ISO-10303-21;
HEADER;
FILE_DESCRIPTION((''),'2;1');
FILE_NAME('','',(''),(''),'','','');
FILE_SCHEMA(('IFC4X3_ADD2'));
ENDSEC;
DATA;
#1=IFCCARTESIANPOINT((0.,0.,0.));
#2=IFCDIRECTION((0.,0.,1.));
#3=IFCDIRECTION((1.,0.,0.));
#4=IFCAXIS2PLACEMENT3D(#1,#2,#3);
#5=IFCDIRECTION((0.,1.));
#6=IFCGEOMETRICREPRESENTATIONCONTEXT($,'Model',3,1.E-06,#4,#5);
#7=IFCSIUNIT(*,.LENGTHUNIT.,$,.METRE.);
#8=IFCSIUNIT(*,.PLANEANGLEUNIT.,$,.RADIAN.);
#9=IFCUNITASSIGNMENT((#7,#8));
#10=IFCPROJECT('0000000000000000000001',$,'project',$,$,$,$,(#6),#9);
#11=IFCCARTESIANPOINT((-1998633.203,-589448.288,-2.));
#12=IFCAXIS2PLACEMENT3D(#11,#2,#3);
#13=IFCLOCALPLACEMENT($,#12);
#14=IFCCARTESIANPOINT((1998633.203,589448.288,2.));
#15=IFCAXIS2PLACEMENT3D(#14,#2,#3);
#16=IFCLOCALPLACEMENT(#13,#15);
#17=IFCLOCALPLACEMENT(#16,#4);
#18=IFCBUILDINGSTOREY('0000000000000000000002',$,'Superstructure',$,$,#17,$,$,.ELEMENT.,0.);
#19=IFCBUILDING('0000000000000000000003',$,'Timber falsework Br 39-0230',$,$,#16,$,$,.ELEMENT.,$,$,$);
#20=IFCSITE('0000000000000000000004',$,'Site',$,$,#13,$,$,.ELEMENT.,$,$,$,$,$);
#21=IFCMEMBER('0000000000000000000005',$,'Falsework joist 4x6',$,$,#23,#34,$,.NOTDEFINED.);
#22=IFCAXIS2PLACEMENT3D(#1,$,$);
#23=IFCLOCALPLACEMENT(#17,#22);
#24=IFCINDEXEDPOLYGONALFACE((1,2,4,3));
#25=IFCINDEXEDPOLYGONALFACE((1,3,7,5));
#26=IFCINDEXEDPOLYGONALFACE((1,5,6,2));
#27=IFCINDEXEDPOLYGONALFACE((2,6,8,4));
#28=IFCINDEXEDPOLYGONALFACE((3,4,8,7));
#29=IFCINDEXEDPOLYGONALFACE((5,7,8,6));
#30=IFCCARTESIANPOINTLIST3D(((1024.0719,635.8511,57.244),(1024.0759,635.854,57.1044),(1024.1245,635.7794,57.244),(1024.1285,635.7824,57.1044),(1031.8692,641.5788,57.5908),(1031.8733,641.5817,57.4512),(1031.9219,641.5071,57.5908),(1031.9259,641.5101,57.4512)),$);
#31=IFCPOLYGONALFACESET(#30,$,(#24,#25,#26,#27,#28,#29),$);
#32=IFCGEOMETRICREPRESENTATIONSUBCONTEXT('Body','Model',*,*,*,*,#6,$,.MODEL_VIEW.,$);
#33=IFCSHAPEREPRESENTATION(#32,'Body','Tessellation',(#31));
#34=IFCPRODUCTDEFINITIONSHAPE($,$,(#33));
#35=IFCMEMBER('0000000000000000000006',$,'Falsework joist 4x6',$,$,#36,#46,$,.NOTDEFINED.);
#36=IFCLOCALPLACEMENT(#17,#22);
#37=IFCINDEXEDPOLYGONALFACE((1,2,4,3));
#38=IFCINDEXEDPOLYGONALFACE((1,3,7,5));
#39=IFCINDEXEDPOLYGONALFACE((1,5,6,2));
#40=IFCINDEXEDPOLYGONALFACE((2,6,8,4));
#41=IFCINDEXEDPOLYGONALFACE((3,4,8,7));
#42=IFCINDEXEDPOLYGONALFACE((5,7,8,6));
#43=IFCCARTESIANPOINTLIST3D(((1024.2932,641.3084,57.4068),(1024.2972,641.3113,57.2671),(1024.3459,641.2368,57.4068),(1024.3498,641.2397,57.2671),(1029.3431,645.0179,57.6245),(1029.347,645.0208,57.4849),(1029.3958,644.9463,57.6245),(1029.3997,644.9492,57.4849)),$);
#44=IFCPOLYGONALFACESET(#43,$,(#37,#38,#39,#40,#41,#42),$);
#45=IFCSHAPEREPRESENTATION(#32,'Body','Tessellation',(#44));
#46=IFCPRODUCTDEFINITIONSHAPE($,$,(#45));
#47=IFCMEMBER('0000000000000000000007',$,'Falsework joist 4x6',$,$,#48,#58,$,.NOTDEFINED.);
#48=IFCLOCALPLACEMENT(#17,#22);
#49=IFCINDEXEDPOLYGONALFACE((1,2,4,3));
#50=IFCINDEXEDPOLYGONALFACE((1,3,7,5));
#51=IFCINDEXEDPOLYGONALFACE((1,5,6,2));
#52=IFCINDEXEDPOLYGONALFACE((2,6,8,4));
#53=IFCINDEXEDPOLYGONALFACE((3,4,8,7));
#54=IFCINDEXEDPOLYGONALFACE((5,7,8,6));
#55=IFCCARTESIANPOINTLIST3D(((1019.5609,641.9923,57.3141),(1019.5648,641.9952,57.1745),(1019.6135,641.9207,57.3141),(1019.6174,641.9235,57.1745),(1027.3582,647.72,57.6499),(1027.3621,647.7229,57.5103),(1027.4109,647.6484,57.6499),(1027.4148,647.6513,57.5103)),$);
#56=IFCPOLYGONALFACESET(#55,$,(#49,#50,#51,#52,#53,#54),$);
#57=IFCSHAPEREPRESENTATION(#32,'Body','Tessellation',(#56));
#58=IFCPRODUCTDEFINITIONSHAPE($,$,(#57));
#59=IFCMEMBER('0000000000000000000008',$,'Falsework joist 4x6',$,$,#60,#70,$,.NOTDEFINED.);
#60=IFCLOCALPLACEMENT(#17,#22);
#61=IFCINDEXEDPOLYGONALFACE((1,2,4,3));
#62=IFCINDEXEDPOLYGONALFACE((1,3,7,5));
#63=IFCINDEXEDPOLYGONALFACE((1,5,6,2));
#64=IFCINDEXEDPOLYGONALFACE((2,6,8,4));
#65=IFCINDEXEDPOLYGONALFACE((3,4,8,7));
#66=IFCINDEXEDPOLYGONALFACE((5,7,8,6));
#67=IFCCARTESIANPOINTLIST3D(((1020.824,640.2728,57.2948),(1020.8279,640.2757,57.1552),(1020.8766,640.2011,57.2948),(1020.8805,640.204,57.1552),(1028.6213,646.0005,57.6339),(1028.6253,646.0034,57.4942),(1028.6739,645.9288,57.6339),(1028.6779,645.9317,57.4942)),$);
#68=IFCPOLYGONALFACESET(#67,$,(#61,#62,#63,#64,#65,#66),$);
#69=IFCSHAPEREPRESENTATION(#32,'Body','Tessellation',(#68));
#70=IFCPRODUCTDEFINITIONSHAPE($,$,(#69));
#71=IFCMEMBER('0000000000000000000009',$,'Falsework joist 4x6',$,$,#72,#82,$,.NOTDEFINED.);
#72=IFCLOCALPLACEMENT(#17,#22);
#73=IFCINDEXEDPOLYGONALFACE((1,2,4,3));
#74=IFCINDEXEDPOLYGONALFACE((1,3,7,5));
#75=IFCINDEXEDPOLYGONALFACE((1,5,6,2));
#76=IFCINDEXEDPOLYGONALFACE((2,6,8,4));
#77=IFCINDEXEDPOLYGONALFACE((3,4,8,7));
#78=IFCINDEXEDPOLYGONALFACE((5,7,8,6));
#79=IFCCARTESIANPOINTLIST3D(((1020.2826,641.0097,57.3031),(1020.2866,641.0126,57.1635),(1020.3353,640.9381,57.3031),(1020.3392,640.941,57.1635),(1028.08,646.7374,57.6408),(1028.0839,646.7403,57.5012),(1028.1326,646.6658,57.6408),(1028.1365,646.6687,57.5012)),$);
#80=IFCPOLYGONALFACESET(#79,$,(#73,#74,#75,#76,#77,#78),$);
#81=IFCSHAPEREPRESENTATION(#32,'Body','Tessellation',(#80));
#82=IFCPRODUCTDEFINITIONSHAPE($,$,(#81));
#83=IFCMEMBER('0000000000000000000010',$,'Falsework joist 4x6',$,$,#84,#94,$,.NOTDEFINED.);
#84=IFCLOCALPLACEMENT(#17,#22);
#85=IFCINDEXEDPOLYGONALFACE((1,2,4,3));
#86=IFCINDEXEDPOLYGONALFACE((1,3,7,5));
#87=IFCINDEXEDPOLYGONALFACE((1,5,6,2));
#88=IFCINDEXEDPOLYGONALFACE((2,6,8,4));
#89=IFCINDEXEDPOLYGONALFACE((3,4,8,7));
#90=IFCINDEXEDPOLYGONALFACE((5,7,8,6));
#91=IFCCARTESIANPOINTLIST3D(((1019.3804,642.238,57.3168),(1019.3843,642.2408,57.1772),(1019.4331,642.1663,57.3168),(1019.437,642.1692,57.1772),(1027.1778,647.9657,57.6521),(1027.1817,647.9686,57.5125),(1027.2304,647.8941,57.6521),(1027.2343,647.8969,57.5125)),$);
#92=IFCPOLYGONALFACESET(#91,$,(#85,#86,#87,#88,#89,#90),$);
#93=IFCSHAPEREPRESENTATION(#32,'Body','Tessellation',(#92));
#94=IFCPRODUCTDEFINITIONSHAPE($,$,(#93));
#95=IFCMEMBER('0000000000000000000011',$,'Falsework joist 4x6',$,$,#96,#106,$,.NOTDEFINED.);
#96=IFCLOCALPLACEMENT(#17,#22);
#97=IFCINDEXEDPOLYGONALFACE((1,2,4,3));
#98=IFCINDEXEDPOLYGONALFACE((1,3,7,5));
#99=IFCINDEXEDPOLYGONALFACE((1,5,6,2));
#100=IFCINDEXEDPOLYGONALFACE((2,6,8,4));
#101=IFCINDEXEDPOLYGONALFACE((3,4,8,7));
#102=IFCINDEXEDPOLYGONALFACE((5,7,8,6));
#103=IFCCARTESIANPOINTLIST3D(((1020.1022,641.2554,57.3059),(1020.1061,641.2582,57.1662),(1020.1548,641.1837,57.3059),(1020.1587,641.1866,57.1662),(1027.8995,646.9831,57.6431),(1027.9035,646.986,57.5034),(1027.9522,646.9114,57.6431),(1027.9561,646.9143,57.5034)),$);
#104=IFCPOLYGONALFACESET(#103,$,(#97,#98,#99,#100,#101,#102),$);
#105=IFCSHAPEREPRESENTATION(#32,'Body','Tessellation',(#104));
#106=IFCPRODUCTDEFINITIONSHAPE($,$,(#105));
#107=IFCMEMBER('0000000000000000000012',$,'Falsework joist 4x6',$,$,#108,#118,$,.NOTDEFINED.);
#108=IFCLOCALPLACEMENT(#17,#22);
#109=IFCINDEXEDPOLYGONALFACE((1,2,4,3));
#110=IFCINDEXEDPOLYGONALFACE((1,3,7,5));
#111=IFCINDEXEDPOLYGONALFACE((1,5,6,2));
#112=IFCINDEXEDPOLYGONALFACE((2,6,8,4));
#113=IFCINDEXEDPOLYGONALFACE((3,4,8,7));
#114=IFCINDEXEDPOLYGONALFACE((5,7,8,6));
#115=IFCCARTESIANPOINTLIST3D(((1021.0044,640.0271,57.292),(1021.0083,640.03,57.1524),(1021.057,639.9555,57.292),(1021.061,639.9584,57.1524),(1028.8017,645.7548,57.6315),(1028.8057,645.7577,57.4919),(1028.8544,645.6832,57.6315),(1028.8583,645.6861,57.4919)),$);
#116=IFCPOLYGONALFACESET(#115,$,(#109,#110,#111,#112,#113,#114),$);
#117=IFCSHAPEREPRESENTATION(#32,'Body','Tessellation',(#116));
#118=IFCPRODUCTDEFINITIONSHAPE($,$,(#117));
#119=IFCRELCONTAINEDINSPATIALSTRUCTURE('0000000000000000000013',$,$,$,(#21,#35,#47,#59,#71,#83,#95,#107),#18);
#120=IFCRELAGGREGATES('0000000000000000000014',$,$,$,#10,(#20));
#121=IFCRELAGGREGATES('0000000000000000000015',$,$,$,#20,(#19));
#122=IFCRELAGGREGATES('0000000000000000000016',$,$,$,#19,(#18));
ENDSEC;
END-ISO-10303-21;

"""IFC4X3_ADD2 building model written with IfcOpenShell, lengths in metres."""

from ifc_helpers import new_model, si_unit, direction, frame, frame_2d, origin, origin_with_axes, place, context, subcontext, project, spatial, rectangle, extrude, element, save


model = new_model("IFC4X3_ADD2")

# Units and contexts
model_context = context("Model", 3, precision=1e-06, world=origin_with_axes(), true_north=direction((0.0, 1.0)))
body_context = subcontext(model_context, "Body", "Model", "MODEL_VIEW")
ifc_project = project(units=[si_unit("LENGTHUNIT", "METRE"), si_unit("PLANEANGLEUNIT", "RADIAN")], contexts=[model_context])

# Site, building, storey
site_placement = place(None, frame((-1998633.203, -589448.288, -2.0), z_axis=(0.0, 0.0, 1.0), x_axis=(1.0, 0.0, 0.0)))
site = spatial("IfcSite", under=ifc_project, at=site_placement, Name="Site", CompositionType="ELEMENT")
building_placement = place(site_placement, frame((1998633.203, 589448.288, 2.0), z_axis=(0.0, 0.0, 1.0), x_axis=(1.0, 0.0, 0.0)))
building = spatial("IfcBuilding", under=site, at=building_placement, Name="Timber falsework Br 39-0230", CompositionType="ELEMENT")
storey_placement = place(building_placement, origin_with_axes())
storey = spatial("IfcBuildingStorey", under=building, at=storey_placement, Name="Superstructure", CompositionType="ELEMENT", Elevation=0.0)

# Members
member_1_placement = place(storey_placement, frame((1024.1022, 635.8182, 57.1044), z_axis=(0.805411, 0.591633, 0.035824), x_axis=(-0.592013, 0.805928, 0.0)))
element("IfcMember", 1, at=member_1_placement, inside=storey, Name="Falsework joist 4x6", PredefinedType="NOTDEFINED", context=body_context, shape_type="SweptSolid", body=[
    extrude(rectangle(XDim=0.0889, YDim=0.1397, at=frame_2d((0.0, 0.0698))), origin(), (0.0, 0.0, 1.0), 9.6812),
])
member_2_placement = place(storey_placement, frame((1024.3235, 641.2755, 57.2671), z_axis=(0.805442, 0.591656, 0.034733), x_axis=(-0.592013, 0.805928, 0.0)))
element("IfcMember", 2, at=member_2_placement, inside=storey, Name="Falsework joist 4x6", PredefinedType="NOTDEFINED", context=body_context, shape_type="SweptSolid", body=[
    extrude(rectangle(XDim=0.0889, YDim=0.1397, at=frame_2d((0.0, 0.0698))), origin(), (0.0, 0.0, 1.0), 6.2697),
])
member_3_placement = place(storey_placement, frame((1019.5911, 641.9594, 57.1745), z_axis=(0.805443, 0.591657, 0.034688), x_axis=(-0.592013, 0.805928, 0.0)))
element("IfcMember", 3, at=member_3_placement, inside=storey, Name="Falsework joist 4x6", PredefinedType="NOTDEFINED", context=body_context, shape_type="SweptSolid", body=[
    extrude(rectangle(XDim=0.0889, YDim=0.1397, at=frame_2d((0.0, 0.0698))), origin(), (0.0, 0.0, 1.0), 9.6808),
])
member_4_placement = place(storey_placement, frame((1020.8542, 640.2398, 57.1552), z_axis=(0.805434, 0.59165, 0.035023), x_axis=(-0.592013, 0.805928, 0.0)))
element("IfcMember", 4, at=member_4_placement, inside=storey, Name="Falsework joist 4x6", PredefinedType="NOTDEFINED", context=body_context, shape_type="SweptSolid", body=[
    extrude(rectangle(XDim=0.0889, YDim=0.1397, at=frame_2d((0.0, 0.0698))), origin(), (0.0, 0.0, 1.0), 9.6809),
])
member_5_placement = place(storey_placement, frame((1020.3129, 640.9768, 57.1635), z_axis=(0.805438, 0.591653, 0.03488), x_axis=(-0.592013, 0.805928, 0.0)))
element("IfcMember", 5, at=member_5_placement, inside=storey, Name="Falsework joist 4x6", PredefinedType="NOTDEFINED", context=body_context, shape_type="SweptSolid", body=[
    extrude(rectangle(XDim=0.0889, YDim=0.1397, at=frame_2d((0.0, 0.0698))), origin(), (0.0, 0.0, 1.0), 9.6809),
])
member_6_placement = place(storey_placement, frame((1019.4106, 642.205, 57.1772), z_axis=(0.805445, 0.591658, 0.03464), x_axis=(-0.592013, 0.805928, 0.0)))
element("IfcMember", 6, at=member_6_placement, inside=storey, Name="Falsework joist 4x6", PredefinedType="NOTDEFINED", context=body_context, shape_type="SweptSolid", body=[
    extrude(rectangle(XDim=0.0889, YDim=0.1397, at=frame_2d((0.0, 0.0698))), origin(), (0.0, 0.0, 1.0), 9.6808),
])
member_7_placement = place(storey_placement, frame((1020.1324, 641.2224, 57.1662), z_axis=(0.805439, 0.591654, 0.034832), x_axis=(-0.592013, 0.805928, 0.0)))
element("IfcMember", 7, at=member_7_placement, inside=storey, Name="Falsework joist 4x6", PredefinedType="NOTDEFINED", context=body_context, shape_type="SweptSolid", body=[
    extrude(rectangle(XDim=0.0889, YDim=0.1397, at=frame_2d((0.0, 0.0698))), origin(), (0.0, 0.0, 1.0), 9.6809),
])
member_8_placement = place(storey_placement, frame((1021.0347, 639.9942, 57.1524), z_axis=(0.805433, 0.591649, 0.035068), x_axis=(-0.592013, 0.805928, 0.0)))
element("IfcMember", 8, at=member_8_placement, inside=storey, Name="Falsework joist 4x6", PredefinedType="NOTDEFINED", context=body_context, shape_type="SweptSolid", body=[
    extrude(rectangle(XDim=0.0889, YDim=0.1397, at=frame_2d((0.0, 0.0698))), origin(), (0.0, 0.0, 1.0), 9.681),
])

save(model, "model.ifc")
